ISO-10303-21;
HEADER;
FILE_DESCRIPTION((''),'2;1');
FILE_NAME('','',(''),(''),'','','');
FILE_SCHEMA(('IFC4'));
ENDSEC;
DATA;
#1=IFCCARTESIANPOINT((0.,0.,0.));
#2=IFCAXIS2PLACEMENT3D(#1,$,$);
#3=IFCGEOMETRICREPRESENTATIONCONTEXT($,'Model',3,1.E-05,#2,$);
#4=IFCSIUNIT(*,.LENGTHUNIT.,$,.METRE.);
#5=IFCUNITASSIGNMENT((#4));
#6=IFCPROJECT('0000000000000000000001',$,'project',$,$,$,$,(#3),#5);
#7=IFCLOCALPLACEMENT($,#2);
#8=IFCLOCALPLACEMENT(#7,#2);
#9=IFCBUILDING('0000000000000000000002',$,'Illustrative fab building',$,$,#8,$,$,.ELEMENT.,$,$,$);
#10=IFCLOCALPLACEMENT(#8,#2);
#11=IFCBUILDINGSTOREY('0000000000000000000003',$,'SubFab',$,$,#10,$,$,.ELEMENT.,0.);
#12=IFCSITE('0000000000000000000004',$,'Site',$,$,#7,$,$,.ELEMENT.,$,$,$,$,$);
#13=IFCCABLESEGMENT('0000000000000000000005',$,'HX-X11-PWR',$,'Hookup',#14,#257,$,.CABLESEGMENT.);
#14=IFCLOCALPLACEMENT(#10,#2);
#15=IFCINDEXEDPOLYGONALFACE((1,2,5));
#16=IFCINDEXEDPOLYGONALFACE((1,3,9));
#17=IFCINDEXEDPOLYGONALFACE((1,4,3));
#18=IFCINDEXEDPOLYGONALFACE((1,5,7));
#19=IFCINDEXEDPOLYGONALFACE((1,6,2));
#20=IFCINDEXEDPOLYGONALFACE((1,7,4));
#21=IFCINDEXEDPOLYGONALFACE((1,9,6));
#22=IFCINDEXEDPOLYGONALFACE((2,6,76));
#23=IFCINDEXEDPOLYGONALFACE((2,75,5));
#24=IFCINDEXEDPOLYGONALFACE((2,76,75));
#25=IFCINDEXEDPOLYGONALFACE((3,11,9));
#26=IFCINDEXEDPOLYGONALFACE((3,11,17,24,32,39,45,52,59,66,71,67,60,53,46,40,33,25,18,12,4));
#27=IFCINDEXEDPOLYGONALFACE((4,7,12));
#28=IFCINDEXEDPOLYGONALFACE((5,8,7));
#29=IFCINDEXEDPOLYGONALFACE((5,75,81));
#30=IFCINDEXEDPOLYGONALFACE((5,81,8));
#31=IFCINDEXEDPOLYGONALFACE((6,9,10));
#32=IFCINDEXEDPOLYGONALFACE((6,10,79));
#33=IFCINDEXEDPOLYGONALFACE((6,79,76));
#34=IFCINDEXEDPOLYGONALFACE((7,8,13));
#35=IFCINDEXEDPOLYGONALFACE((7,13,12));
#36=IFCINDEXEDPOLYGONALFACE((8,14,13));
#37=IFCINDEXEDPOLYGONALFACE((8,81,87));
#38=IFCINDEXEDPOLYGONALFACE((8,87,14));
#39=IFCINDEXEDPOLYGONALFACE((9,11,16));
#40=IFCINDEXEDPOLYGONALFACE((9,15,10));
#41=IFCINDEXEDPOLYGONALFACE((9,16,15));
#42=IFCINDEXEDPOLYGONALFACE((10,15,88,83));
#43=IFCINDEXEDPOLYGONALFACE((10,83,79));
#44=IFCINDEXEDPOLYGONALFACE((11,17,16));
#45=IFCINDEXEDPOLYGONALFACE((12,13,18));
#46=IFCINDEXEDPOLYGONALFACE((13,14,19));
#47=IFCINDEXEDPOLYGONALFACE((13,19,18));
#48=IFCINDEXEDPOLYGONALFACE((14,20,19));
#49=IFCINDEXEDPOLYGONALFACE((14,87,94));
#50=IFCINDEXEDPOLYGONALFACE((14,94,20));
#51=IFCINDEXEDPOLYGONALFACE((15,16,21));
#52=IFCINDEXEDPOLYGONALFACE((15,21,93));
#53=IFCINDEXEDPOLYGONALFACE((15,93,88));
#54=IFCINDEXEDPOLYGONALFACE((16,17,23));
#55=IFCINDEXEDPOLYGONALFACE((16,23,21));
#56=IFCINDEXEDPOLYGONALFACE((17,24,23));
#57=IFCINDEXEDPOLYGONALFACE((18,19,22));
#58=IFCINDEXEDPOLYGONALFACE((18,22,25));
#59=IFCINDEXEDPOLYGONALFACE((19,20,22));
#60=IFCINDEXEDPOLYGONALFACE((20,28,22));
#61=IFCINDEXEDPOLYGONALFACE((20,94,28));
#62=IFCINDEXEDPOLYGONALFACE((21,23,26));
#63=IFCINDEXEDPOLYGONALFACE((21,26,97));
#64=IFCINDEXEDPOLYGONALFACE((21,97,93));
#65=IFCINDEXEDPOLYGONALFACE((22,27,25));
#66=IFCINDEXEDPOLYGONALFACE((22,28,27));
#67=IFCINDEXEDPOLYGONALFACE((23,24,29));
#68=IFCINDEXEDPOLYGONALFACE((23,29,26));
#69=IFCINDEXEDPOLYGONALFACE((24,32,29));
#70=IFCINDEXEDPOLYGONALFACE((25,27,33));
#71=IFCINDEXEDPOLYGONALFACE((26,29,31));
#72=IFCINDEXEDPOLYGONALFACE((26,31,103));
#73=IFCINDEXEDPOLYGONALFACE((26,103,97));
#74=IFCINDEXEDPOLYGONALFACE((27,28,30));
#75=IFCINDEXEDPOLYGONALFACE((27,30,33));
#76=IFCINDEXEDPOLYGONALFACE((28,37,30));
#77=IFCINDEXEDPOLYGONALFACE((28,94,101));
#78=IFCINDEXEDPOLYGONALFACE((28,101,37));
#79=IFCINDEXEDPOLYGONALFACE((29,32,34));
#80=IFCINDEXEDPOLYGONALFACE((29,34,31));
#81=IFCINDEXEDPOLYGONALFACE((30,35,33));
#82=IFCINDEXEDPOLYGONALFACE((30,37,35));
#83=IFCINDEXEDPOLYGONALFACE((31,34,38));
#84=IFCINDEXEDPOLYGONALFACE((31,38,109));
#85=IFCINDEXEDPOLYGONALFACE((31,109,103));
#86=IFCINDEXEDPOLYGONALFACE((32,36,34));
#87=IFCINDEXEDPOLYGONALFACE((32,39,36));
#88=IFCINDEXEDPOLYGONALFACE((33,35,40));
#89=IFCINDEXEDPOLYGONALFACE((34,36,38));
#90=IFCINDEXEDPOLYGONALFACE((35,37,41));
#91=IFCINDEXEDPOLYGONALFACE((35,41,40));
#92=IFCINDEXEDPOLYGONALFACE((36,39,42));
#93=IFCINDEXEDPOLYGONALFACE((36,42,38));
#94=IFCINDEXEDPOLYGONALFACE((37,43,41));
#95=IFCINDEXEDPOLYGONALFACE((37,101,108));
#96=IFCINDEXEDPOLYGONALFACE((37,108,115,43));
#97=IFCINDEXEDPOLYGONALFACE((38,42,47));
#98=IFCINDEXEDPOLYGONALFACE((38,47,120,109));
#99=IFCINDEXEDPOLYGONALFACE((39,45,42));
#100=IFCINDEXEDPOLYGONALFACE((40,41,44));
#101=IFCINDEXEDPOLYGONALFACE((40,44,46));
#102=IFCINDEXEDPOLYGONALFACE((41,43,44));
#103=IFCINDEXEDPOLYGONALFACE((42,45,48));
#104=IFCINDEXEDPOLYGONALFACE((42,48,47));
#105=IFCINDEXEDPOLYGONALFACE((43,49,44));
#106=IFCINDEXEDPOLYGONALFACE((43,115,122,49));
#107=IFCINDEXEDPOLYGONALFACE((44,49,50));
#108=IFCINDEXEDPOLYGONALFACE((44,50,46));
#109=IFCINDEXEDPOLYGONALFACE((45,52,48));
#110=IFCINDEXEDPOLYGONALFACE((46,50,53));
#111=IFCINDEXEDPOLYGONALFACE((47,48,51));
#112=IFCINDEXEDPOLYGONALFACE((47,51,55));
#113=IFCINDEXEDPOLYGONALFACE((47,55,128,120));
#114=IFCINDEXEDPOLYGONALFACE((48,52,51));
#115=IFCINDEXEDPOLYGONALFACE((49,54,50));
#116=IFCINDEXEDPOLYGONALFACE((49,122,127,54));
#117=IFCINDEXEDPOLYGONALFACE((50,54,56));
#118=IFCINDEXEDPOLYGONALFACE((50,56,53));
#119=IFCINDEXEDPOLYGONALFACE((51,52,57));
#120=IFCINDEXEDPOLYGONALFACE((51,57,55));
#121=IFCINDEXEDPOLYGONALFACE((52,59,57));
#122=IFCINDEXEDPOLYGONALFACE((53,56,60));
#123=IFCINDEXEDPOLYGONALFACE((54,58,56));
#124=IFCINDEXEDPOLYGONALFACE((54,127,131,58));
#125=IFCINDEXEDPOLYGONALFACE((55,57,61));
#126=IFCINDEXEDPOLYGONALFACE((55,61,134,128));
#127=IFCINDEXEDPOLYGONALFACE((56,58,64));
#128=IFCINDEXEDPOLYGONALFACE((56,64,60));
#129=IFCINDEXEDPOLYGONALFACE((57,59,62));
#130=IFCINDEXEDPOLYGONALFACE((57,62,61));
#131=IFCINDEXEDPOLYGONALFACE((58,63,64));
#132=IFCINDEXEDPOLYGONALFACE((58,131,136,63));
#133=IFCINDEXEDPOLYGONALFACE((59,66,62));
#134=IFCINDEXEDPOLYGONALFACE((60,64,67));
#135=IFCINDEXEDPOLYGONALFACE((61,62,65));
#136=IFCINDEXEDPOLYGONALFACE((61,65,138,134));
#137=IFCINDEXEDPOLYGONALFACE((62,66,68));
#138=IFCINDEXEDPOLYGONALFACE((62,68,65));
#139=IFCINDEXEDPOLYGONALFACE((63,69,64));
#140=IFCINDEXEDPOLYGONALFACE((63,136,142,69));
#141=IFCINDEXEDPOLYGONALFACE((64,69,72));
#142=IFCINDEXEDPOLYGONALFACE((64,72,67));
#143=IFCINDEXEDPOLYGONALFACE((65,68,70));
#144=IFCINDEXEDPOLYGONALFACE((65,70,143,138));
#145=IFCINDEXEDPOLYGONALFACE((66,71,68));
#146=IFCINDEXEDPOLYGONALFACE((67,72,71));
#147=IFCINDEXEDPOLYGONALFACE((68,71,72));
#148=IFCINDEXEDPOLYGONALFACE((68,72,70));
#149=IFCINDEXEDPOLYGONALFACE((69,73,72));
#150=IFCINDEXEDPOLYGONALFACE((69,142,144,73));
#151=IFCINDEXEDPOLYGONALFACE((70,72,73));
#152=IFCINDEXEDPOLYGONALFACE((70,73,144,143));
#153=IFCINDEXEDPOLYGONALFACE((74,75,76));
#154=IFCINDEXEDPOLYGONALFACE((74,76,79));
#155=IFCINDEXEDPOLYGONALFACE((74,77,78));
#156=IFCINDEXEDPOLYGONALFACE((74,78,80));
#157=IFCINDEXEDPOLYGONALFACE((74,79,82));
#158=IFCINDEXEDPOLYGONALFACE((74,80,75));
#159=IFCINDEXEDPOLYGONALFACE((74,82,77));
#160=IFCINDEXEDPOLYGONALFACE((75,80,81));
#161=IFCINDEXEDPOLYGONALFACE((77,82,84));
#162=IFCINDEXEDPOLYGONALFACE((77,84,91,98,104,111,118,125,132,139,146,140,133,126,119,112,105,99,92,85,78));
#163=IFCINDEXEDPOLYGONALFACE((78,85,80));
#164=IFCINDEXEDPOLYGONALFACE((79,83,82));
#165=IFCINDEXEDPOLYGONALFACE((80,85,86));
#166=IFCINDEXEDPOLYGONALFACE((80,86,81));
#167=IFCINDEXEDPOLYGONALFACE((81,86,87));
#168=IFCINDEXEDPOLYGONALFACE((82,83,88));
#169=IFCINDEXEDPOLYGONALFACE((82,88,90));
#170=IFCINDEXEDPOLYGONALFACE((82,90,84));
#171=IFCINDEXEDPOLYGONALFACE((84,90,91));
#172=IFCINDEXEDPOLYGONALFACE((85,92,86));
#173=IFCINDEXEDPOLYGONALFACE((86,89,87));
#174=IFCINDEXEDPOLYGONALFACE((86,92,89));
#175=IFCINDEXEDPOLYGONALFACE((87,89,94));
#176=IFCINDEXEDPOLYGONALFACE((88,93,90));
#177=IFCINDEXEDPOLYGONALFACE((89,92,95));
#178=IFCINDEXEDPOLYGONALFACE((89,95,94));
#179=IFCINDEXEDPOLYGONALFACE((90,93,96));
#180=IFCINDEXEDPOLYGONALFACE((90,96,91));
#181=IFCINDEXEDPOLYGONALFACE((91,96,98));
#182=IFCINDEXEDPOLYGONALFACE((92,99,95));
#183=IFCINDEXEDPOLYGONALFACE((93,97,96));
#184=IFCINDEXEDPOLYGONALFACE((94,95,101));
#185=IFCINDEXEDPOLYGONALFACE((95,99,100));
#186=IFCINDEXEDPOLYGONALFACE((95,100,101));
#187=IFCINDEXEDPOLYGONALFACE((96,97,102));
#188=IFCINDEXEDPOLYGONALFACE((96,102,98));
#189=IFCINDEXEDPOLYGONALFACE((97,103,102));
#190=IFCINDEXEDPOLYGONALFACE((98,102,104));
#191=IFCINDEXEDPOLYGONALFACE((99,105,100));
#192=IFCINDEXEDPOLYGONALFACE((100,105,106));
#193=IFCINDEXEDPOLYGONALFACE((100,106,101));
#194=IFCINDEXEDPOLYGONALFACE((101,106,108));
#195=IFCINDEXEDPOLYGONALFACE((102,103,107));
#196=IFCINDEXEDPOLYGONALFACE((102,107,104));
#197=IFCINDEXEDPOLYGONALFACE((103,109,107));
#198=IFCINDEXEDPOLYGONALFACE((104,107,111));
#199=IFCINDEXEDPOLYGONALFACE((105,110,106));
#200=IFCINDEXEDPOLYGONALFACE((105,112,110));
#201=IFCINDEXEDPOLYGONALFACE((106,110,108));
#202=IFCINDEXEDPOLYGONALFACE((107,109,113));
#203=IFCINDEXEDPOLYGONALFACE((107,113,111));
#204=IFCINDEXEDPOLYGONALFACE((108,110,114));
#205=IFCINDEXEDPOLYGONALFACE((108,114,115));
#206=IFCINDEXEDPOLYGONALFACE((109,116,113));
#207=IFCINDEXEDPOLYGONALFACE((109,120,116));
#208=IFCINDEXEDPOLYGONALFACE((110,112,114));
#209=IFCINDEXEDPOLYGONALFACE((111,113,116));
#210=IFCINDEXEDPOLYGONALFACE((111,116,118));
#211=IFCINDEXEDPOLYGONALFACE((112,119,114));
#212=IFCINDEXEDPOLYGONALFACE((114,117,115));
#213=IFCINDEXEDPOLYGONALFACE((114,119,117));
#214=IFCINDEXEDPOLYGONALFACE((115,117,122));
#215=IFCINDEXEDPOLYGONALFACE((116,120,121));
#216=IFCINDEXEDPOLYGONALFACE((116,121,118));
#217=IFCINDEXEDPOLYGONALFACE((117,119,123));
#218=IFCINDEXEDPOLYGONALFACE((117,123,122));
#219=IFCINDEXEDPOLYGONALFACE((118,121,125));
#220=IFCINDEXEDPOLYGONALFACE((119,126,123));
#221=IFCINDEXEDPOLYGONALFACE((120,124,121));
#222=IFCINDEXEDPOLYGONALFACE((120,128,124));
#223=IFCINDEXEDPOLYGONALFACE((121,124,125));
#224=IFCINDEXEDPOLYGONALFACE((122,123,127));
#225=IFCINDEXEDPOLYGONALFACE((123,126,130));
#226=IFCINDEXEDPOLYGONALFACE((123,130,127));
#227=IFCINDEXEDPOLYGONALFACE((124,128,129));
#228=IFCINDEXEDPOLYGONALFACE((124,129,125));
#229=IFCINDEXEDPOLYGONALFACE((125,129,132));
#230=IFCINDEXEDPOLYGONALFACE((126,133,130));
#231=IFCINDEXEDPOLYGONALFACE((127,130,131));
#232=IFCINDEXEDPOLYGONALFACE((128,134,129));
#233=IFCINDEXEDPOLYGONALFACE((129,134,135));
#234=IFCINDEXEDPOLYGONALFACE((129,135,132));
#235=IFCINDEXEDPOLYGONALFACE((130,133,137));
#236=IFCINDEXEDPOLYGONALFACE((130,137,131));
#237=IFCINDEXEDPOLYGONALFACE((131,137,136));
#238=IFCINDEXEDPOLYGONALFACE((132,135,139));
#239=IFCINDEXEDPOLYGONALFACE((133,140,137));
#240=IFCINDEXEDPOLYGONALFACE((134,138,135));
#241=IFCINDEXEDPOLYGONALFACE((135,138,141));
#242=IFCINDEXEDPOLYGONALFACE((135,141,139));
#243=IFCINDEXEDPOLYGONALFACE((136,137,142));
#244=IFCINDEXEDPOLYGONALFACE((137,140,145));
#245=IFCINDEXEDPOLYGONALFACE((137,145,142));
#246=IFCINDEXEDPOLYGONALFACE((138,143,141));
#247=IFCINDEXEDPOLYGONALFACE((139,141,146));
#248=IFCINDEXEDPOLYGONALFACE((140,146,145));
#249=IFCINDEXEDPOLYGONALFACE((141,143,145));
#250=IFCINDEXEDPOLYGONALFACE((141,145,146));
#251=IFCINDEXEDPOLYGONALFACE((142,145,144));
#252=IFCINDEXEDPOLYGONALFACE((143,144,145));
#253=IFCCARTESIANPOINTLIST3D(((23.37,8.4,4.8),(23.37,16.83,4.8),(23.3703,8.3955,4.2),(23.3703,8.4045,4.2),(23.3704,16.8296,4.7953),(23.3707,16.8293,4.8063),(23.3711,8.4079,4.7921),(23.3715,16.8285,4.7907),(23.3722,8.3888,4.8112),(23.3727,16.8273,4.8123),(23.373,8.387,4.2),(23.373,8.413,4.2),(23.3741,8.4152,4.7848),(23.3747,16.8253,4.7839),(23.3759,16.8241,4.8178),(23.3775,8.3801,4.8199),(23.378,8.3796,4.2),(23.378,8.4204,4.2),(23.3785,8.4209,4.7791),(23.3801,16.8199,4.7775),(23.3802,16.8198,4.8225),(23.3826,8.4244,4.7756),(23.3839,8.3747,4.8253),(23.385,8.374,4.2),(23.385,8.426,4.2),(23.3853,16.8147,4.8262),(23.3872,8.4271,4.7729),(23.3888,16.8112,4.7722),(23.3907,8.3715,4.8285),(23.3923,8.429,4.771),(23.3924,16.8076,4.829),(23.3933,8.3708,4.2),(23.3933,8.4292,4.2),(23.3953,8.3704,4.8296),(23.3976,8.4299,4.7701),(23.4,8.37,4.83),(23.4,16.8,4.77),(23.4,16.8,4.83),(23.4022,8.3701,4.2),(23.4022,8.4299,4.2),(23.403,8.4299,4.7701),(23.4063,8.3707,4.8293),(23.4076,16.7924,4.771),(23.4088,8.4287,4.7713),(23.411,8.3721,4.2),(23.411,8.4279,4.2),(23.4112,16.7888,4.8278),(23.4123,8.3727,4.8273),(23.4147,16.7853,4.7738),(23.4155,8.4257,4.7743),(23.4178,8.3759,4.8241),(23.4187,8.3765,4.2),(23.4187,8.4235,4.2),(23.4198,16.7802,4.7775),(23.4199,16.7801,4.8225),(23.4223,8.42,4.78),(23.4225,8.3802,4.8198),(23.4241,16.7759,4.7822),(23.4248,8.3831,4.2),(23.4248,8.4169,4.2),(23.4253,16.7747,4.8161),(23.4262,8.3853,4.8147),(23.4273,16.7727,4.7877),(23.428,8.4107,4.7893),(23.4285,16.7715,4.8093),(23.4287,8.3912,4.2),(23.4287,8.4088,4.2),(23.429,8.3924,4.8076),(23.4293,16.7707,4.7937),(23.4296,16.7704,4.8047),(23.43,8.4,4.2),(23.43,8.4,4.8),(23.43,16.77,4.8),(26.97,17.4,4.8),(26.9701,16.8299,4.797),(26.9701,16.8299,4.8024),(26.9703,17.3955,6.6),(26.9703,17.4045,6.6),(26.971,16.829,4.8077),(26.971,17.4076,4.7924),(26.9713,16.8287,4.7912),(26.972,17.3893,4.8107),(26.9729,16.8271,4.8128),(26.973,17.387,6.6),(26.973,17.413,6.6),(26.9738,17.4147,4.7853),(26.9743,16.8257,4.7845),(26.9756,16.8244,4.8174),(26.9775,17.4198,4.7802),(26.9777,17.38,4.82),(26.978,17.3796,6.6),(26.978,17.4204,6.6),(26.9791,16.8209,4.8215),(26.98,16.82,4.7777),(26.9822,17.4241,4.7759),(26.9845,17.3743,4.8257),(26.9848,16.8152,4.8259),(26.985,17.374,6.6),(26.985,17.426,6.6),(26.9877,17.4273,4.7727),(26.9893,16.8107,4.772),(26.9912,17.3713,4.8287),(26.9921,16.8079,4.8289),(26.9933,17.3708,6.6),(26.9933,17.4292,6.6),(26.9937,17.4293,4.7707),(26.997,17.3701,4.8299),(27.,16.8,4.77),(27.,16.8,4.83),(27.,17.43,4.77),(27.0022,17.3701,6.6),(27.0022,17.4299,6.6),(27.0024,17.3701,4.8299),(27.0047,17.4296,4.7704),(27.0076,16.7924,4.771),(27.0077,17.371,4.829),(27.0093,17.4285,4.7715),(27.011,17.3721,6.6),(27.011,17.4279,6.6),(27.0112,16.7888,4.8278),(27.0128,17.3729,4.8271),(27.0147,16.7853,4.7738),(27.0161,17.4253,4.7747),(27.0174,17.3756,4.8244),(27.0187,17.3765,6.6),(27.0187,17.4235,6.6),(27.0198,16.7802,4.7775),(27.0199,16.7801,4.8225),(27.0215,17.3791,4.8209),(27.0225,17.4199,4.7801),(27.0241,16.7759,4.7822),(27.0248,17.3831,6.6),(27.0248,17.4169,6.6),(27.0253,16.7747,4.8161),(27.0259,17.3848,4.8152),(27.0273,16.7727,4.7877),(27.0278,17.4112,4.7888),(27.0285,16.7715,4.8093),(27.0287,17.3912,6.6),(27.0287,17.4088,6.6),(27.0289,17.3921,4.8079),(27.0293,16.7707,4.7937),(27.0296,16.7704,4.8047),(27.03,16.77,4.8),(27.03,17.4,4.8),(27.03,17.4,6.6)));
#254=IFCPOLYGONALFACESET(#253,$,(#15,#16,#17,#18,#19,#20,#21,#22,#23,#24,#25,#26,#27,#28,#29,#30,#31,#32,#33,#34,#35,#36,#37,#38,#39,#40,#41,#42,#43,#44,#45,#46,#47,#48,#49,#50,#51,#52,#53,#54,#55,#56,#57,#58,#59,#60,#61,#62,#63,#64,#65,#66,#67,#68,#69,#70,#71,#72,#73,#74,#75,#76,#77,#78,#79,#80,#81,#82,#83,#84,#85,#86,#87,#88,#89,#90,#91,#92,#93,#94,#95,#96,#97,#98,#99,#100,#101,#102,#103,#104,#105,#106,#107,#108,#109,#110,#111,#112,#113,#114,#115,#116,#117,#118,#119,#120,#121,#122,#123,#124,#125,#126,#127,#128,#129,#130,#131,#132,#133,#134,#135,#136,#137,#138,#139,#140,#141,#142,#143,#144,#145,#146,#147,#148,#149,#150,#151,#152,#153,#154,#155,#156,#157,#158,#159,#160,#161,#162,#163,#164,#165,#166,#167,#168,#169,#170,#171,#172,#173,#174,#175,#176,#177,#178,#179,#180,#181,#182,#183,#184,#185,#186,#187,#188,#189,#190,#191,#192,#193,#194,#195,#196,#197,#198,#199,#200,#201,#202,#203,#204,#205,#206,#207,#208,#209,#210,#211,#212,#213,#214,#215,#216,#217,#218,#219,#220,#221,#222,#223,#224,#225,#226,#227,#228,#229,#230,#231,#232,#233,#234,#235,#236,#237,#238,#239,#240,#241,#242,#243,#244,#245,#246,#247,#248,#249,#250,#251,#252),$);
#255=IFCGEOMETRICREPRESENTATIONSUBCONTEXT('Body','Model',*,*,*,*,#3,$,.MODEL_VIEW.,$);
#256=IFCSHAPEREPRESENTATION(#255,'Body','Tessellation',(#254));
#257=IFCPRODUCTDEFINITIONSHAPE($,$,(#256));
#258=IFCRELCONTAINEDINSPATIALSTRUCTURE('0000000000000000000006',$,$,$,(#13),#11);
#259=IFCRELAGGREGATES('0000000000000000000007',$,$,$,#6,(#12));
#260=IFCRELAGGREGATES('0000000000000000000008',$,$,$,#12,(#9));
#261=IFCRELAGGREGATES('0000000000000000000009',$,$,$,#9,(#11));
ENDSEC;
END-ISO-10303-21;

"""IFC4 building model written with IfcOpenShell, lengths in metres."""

from ifc_helpers import new_model, entity, si_unit, origin, place, context, subcontext, project, spatial, element, save


model = new_model("IFC4")

# Units and contexts
model_context = context("Model", 3, precision=1e-05, world=origin())
body_context = subcontext(model_context, "Body", "Model", "MODEL_VIEW")
ifc_project = project(units=[si_unit("LENGTHUNIT", "METRE")], contexts=[model_context])

# Site, building, storey
site_placement = place(None, origin())
site = spatial("IfcSite", under=ifc_project, at=site_placement, Name="Site", CompositionType="ELEMENT")
building_placement = place(site_placement, origin())
building = spatial("IfcBuilding", under=site, at=building_placement, Name="Illustrative fab building", CompositionType="ELEMENT")
storey_placement = place(building_placement, origin())
storey = spatial("IfcBuildingStorey", under=building, at=storey_placement, Name="SubFab", CompositionType="ELEMENT", Elevation=0.0)

# Cable segment
cable_segment_1_placement = place(storey_placement, origin())
element("IfcCableSegment", 1, at=cable_segment_1_placement, inside=storey, Name="HX-X11-PWR", ObjectType="Hookup", PredefinedType="CABLESEGMENT", context=body_context, shape_type="AdvancedSweptSolid", body=[
    entity("IfcSweptDiskSolid", entity("IfcPolyline", [entity("IfcCartesianPoint", [23.4, 8.4, 4.2]), entity("IfcCartesianPoint", [23.4, 8.4, 4.8]), entity("IfcCartesianPoint", [23.4, 16.8, 4.8]), entity("IfcCartesianPoint", [27.0, 16.8, 4.8]), entity("IfcCartesianPoint", [27.0, 17.4, 4.8]), entity("IfcCartesianPoint", [27.0, 17.4, 6.6])]), 0.03),
])

save(model, "model.ifc")
